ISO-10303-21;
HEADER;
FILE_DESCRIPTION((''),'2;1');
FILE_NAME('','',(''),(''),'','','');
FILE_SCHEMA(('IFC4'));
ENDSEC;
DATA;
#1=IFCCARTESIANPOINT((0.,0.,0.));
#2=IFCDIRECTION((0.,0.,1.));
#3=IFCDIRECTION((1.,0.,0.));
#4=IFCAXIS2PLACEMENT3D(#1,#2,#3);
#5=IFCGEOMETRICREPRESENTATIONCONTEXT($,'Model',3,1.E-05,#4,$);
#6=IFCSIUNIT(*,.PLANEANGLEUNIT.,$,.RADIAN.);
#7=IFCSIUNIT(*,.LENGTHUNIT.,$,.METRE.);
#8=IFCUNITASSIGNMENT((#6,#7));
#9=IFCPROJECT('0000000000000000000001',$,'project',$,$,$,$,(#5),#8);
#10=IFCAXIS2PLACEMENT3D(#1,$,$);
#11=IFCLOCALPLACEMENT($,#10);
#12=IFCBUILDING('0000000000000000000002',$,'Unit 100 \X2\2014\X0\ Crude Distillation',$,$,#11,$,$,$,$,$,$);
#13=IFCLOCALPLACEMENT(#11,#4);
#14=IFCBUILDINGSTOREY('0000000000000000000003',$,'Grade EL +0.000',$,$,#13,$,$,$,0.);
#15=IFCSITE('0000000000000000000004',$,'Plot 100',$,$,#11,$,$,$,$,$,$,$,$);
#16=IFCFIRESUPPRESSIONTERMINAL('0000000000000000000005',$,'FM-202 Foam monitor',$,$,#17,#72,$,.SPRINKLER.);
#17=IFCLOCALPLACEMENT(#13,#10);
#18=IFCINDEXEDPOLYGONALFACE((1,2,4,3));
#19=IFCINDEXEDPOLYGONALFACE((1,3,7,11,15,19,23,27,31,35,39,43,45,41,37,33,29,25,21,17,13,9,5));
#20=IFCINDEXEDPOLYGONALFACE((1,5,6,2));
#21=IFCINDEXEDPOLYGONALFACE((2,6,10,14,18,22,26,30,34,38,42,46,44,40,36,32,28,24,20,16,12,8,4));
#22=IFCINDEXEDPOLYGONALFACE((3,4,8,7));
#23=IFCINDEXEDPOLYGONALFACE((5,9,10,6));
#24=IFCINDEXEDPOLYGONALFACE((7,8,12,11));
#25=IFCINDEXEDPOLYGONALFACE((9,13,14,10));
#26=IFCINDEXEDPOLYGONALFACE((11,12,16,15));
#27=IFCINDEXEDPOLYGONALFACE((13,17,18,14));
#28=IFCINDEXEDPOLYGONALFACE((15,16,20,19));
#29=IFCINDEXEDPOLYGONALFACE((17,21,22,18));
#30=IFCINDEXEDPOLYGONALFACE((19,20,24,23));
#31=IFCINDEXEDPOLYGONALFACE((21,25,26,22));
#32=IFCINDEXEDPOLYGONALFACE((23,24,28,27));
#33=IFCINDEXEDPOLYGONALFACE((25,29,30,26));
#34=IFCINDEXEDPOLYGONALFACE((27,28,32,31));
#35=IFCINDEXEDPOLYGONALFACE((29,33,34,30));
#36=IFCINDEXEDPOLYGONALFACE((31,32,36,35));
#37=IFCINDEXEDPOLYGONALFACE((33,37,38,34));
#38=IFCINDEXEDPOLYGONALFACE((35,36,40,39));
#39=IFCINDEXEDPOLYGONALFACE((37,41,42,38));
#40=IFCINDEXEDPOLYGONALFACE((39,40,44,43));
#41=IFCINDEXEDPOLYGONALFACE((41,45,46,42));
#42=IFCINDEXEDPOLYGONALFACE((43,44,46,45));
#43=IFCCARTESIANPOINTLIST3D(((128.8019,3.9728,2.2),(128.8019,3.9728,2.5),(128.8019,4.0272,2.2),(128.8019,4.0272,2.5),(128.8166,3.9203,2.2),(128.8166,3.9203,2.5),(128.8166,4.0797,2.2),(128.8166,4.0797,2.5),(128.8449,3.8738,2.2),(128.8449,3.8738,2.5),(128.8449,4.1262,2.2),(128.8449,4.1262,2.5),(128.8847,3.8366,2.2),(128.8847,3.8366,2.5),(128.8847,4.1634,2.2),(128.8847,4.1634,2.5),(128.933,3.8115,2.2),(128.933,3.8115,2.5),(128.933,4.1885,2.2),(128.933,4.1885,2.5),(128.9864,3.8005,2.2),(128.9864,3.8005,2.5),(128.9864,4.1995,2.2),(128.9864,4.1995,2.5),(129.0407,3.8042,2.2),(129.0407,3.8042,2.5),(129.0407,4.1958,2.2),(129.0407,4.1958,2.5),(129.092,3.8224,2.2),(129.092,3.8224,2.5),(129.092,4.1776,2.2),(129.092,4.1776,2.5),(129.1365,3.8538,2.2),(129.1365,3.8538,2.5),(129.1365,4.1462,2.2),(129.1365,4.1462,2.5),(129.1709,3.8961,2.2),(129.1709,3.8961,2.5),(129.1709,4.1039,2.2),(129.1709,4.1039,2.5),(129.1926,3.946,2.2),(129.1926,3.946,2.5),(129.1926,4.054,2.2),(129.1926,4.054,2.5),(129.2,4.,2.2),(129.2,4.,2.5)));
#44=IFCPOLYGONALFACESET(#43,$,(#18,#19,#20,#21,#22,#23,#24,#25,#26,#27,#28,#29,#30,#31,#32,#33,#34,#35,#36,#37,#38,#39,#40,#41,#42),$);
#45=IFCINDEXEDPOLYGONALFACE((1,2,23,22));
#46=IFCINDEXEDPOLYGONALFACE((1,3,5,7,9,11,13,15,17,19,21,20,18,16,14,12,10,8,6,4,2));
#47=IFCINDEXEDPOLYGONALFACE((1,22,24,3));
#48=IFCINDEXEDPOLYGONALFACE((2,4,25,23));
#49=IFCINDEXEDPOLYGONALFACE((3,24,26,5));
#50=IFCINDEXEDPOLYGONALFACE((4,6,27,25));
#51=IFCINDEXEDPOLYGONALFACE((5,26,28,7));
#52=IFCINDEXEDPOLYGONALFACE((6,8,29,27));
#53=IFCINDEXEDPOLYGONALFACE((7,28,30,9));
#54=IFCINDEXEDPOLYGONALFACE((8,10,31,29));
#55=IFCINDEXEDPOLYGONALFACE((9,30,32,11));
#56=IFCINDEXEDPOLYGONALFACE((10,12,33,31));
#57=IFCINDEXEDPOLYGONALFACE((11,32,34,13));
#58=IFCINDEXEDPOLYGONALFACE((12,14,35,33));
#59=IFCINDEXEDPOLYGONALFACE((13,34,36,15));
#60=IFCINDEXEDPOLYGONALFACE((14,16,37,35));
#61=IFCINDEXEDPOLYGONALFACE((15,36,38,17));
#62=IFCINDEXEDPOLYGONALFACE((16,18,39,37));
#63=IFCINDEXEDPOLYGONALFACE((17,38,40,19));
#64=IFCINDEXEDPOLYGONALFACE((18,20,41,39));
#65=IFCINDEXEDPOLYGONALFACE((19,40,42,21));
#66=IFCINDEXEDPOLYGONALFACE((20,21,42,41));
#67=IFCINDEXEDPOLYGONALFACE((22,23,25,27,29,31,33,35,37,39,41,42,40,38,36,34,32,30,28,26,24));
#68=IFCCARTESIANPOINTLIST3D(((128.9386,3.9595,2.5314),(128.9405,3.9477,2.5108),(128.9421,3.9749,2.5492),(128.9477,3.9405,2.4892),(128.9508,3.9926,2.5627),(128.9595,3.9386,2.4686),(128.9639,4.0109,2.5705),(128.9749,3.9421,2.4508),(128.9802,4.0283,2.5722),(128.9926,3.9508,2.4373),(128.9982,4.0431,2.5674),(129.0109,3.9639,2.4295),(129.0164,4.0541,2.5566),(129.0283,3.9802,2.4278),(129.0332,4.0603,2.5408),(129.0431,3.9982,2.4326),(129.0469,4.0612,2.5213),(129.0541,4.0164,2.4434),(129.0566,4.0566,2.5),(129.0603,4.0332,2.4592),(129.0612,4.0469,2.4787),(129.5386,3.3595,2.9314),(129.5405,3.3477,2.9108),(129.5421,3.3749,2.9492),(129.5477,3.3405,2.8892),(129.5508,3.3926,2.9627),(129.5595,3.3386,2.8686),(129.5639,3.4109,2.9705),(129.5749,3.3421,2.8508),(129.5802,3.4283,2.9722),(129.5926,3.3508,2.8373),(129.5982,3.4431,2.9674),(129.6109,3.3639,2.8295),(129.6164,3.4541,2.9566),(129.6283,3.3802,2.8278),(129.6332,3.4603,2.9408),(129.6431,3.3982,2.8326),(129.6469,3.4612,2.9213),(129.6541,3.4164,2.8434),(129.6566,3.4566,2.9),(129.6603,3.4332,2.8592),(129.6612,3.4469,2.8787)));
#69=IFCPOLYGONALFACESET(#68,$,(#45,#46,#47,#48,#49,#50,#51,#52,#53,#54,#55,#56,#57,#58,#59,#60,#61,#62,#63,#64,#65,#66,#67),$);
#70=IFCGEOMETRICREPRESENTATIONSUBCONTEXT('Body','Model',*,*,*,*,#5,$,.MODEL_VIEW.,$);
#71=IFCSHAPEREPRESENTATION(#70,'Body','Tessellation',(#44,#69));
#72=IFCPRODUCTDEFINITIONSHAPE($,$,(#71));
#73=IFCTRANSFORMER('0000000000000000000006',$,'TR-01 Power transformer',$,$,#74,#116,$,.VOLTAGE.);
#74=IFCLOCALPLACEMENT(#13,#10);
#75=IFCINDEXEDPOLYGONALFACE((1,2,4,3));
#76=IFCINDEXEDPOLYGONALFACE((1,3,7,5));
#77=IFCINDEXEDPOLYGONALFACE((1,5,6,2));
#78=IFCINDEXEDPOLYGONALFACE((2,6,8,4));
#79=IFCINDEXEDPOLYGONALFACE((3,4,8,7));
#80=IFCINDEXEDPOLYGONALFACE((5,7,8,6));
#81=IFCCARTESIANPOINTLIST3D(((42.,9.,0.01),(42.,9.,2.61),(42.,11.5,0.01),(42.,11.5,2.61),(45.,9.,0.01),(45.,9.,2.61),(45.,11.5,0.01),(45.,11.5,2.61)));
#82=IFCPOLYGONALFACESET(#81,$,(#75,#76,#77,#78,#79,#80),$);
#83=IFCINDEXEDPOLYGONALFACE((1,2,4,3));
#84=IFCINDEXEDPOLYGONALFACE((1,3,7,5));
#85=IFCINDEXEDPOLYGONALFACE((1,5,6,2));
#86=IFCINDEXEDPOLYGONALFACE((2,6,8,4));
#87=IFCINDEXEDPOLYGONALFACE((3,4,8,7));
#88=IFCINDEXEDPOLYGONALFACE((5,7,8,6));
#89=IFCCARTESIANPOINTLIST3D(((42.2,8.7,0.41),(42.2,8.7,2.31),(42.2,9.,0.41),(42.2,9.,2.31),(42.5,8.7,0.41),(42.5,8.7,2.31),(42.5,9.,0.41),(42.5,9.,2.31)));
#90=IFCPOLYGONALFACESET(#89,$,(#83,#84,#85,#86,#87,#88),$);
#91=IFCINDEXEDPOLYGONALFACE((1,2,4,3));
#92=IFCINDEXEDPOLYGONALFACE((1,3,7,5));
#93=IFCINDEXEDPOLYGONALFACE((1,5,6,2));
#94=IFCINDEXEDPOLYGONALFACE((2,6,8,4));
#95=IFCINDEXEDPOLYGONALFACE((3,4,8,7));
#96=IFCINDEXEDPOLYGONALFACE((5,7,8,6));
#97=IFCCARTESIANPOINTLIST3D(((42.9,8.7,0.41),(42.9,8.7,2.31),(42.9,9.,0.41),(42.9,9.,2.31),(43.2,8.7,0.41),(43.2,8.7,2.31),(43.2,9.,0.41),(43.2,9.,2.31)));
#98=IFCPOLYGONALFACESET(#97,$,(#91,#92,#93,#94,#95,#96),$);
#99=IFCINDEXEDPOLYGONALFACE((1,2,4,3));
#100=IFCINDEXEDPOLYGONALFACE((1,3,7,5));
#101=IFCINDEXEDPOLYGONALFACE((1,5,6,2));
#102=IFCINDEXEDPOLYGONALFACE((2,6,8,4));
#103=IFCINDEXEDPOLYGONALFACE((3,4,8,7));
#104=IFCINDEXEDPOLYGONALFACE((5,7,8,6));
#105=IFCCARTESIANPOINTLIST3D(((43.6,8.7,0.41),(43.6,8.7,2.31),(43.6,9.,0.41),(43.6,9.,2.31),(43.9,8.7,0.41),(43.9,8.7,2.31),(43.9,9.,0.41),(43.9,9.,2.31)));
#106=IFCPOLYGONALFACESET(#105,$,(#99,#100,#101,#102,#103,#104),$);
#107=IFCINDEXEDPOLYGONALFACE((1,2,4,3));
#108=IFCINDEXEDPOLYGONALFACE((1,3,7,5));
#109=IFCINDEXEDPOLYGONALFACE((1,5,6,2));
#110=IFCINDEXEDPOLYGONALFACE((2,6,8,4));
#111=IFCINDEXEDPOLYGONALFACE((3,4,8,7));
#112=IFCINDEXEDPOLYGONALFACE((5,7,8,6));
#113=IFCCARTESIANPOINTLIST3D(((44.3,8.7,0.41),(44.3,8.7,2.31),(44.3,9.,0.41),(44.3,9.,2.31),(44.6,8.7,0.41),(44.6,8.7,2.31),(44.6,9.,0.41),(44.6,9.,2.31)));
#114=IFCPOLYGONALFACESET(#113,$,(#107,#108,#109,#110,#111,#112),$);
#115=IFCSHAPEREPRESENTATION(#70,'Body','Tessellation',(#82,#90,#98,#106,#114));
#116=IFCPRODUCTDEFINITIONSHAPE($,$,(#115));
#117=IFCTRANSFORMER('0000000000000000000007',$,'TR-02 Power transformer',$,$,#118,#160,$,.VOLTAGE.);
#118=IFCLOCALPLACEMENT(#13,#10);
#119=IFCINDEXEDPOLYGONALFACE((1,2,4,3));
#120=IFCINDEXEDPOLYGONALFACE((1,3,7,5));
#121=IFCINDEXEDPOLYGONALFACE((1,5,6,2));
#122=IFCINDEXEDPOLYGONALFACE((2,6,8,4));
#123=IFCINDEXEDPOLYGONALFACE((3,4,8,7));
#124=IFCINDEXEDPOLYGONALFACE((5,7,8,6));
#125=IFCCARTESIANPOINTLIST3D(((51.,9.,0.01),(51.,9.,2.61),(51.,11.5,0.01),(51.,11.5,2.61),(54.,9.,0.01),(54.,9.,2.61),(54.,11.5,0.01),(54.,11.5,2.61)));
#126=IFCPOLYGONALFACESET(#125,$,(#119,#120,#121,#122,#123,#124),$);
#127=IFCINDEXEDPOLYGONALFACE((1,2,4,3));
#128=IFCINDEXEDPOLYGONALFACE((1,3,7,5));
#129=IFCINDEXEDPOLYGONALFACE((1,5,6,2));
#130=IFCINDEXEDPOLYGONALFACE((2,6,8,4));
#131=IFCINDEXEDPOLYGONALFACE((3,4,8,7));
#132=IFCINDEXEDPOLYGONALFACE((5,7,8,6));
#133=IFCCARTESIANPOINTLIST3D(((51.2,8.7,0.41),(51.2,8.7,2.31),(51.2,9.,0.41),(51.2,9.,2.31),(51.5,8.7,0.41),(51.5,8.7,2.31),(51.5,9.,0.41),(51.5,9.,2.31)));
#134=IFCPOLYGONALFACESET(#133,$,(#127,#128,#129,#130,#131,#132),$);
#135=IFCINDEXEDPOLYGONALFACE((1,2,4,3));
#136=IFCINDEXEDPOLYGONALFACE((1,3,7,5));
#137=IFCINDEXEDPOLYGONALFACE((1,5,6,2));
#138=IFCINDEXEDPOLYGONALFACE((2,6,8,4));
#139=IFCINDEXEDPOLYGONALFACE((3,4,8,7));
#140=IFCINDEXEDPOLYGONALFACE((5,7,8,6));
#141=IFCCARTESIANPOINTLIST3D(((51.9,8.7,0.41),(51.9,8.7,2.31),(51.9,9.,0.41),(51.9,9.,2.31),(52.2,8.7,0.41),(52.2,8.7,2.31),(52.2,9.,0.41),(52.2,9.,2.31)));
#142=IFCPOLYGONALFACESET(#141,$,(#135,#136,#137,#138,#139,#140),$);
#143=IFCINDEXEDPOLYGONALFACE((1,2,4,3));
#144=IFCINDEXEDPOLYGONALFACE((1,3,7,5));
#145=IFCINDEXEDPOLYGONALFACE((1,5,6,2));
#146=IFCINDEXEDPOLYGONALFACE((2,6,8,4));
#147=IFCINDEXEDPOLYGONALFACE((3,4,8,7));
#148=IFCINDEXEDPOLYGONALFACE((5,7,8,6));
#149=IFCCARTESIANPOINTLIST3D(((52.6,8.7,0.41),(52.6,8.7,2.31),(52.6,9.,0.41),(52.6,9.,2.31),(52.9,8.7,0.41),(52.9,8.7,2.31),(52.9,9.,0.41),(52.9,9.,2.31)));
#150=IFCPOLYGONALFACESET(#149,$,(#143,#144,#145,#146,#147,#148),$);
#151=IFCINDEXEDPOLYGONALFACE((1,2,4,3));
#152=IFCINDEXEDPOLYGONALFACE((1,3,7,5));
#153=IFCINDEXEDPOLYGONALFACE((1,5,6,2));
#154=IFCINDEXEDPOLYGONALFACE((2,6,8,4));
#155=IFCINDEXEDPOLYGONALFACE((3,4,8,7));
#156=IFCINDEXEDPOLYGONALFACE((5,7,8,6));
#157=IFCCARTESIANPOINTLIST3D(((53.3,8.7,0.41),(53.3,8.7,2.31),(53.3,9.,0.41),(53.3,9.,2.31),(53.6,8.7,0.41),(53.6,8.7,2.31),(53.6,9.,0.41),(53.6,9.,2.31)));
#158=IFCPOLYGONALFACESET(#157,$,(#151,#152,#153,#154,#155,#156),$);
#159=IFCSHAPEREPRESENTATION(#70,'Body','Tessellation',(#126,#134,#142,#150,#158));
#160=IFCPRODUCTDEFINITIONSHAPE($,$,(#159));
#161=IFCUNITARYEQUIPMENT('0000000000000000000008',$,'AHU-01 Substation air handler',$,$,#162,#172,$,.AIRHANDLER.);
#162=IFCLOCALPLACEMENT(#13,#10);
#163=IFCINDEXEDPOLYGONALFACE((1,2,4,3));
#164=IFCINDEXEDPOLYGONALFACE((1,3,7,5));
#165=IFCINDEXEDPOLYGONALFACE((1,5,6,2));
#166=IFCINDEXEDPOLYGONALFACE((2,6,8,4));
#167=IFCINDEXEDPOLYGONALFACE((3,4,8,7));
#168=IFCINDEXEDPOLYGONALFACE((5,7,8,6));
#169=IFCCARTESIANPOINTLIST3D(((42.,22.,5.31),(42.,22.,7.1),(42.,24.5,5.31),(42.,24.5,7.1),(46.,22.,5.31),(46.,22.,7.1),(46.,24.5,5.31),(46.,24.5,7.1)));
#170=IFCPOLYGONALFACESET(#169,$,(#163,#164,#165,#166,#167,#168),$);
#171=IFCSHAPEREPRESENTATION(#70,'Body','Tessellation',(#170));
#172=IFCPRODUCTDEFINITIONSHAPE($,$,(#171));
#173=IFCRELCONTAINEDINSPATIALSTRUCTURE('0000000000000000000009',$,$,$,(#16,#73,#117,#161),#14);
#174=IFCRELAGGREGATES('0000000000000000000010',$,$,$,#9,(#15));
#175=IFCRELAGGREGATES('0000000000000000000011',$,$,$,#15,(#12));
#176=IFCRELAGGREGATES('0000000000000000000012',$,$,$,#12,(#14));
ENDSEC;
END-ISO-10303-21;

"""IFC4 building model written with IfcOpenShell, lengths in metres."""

from ifc_helpers import new_model, si_unit, frame, origin, origin_with_axes, origin_2d, place, context, subcontext, project, spatial, rectangle, circle, extrude, element, save


model = new_model("IFC4")

# Units and contexts
model_context = context("Model", 3, precision=1e-05, world=origin_with_axes())
body_context = subcontext(model_context, "Body", "Model", "MODEL_VIEW")
ifc_project = project(units=[si_unit("PLANEANGLEUNIT", "RADIAN"), si_unit("LENGTHUNIT", "METRE")], contexts=[model_context])

# Site, building, storey
placement = place(None, origin())
site = spatial("IfcSite", under=ifc_project, at=placement, Name="Plot 100")
building = spatial("IfcBuilding", under=site, at=placement, Name="Unit 100 — Crude Distillation")
storey_placement = place(placement, origin_with_axes())
storey = spatial("IfcBuildingStorey", under=building, at=storey_placement, Name="Grade EL +0.000", Elevation=0.0)

# Fire suppression terminal
fire_suppression_terminal_1_placement = place(storey_placement, origin_with_axes())
element("IfcFireSuppressionTerminal", 1, at=fire_suppression_terminal_1_placement, inside=storey, Name="FM-202 Foam monitor", PredefinedType="SPRINKLER", context=body_context, shape_type="SweptSolid", body=[
    extrude(circle(Radius=0.2, at=origin_2d()), frame((129.0, 4.0, 2.2), z_axis=(0.0, 0.0, 1.0), x_axis=(1.0, 0.0, 0.0)), (0.0, 0.0, 1.0), 0.3),
    extrude(circle(Radius=0.08, at=origin_2d()), frame((129.0, 4.0, 2.5), z_axis=(0.639602, -0.639602, 0.426401), x_axis=(0.707107, 0.707107, 0.0)), (0.0, 0.0, 1.0), 0.9381),
])

# Transformers
transformer_1_placement = place(storey_placement, origin_with_axes())
element("IfcTransformer", 2, at=transformer_1_placement, inside=storey, Name="TR-01 Power transformer", PredefinedType="VOLTAGE", context=body_context, shape_type="SweptSolid", body=[
    extrude(rectangle(XDim=3.0, YDim=2.5, at=origin_2d()), frame((43.5, 10.25, 0.01), z_axis=(0.0, 0.0, 1.0), x_axis=(1.0, 0.0, 0.0)), (0.0, 0.0, 1.0), 2.6),
    extrude(rectangle(XDim=0.3, YDim=0.3, at=origin_2d()), frame((42.35, 8.85, 0.41), z_axis=(0.0, 0.0, 1.0), x_axis=(1.0, 0.0, 0.0)), (0.0, 0.0, 1.0), 1.9),
    extrude(rectangle(XDim=0.3, YDim=0.3, at=origin_2d()), frame((43.05, 8.85, 0.41), z_axis=(0.0, 0.0, 1.0), x_axis=(1.0, 0.0, 0.0)), (0.0, 0.0, 1.0), 1.9),
    extrude(rectangle(XDim=0.3, YDim=0.3, at=origin_2d()), frame((43.75, 8.85, 0.41), z_axis=(0.0, 0.0, 1.0), x_axis=(1.0, 0.0, 0.0)), (0.0, 0.0, 1.0), 1.9),
    extrude(rectangle(XDim=0.3, YDim=0.3, at=origin_2d()), frame((44.45, 8.85, 0.41), z_axis=(0.0, 0.0, 1.0), x_axis=(1.0, 0.0, 0.0)), (0.0, 0.0, 1.0), 1.9),
])
transformer_2_placement = place(storey_placement, origin_with_axes())
element("IfcTransformer", 3, at=transformer_2_placement, inside=storey, Name="TR-02 Power transformer", PredefinedType="VOLTAGE", context=body_context, shape_type="SweptSolid", body=[
    extrude(rectangle(XDim=3.0, YDim=2.5, at=origin_2d()), frame((52.5, 10.25, 0.01), z_axis=(0.0, 0.0, 1.0), x_axis=(1.0, 0.0, 0.0)), (0.0, 0.0, 1.0), 2.6),
    extrude(rectangle(XDim=0.3, YDim=0.3, at=origin_2d()), frame((51.35, 8.85, 0.41), z_axis=(0.0, 0.0, 1.0), x_axis=(1.0, 0.0, 0.0)), (0.0, 0.0, 1.0), 1.9),
    extrude(rectangle(XDim=0.3, YDim=0.3, at=origin_2d()), frame((52.05, 8.85, 0.41), z_axis=(0.0, 0.0, 1.0), x_axis=(1.0, 0.0, 0.0)), (0.0, 0.0, 1.0), 1.9),
    extrude(rectangle(XDim=0.3, YDim=0.3, at=origin_2d()), frame((52.75, 8.85, 0.41), z_axis=(0.0, 0.0, 1.0), x_axis=(1.0, 0.0, 0.0)), (0.0, 0.0, 1.0), 1.9),
    extrude(rectangle(XDim=0.3, YDim=0.3, at=origin_2d()), frame((53.45, 8.85, 0.41), z_axis=(0.0, 0.0, 1.0), x_axis=(1.0, 0.0, 0.0)), (0.0, 0.0, 1.0), 1.9),
])

# Unitary equipment
unitary_equipment_placement = place(storey_placement, origin_with_axes())
element("IfcUnitaryEquipment", 4, at=unitary_equipment_placement, inside=storey, Name="AHU-01 Substation air handler", PredefinedType="AIRHANDLER", context=body_context, shape_type="SweptSolid", body=[
    extrude(rectangle(XDim=4.0, YDim=2.5, at=origin_2d()), frame((44.0, 23.25, 5.31), z_axis=(0.0, 0.0, 1.0), x_axis=(1.0, 0.0, 0.0)), (0.0, 0.0, 1.0), 1.79),
])

save(model, "model.ifc")
